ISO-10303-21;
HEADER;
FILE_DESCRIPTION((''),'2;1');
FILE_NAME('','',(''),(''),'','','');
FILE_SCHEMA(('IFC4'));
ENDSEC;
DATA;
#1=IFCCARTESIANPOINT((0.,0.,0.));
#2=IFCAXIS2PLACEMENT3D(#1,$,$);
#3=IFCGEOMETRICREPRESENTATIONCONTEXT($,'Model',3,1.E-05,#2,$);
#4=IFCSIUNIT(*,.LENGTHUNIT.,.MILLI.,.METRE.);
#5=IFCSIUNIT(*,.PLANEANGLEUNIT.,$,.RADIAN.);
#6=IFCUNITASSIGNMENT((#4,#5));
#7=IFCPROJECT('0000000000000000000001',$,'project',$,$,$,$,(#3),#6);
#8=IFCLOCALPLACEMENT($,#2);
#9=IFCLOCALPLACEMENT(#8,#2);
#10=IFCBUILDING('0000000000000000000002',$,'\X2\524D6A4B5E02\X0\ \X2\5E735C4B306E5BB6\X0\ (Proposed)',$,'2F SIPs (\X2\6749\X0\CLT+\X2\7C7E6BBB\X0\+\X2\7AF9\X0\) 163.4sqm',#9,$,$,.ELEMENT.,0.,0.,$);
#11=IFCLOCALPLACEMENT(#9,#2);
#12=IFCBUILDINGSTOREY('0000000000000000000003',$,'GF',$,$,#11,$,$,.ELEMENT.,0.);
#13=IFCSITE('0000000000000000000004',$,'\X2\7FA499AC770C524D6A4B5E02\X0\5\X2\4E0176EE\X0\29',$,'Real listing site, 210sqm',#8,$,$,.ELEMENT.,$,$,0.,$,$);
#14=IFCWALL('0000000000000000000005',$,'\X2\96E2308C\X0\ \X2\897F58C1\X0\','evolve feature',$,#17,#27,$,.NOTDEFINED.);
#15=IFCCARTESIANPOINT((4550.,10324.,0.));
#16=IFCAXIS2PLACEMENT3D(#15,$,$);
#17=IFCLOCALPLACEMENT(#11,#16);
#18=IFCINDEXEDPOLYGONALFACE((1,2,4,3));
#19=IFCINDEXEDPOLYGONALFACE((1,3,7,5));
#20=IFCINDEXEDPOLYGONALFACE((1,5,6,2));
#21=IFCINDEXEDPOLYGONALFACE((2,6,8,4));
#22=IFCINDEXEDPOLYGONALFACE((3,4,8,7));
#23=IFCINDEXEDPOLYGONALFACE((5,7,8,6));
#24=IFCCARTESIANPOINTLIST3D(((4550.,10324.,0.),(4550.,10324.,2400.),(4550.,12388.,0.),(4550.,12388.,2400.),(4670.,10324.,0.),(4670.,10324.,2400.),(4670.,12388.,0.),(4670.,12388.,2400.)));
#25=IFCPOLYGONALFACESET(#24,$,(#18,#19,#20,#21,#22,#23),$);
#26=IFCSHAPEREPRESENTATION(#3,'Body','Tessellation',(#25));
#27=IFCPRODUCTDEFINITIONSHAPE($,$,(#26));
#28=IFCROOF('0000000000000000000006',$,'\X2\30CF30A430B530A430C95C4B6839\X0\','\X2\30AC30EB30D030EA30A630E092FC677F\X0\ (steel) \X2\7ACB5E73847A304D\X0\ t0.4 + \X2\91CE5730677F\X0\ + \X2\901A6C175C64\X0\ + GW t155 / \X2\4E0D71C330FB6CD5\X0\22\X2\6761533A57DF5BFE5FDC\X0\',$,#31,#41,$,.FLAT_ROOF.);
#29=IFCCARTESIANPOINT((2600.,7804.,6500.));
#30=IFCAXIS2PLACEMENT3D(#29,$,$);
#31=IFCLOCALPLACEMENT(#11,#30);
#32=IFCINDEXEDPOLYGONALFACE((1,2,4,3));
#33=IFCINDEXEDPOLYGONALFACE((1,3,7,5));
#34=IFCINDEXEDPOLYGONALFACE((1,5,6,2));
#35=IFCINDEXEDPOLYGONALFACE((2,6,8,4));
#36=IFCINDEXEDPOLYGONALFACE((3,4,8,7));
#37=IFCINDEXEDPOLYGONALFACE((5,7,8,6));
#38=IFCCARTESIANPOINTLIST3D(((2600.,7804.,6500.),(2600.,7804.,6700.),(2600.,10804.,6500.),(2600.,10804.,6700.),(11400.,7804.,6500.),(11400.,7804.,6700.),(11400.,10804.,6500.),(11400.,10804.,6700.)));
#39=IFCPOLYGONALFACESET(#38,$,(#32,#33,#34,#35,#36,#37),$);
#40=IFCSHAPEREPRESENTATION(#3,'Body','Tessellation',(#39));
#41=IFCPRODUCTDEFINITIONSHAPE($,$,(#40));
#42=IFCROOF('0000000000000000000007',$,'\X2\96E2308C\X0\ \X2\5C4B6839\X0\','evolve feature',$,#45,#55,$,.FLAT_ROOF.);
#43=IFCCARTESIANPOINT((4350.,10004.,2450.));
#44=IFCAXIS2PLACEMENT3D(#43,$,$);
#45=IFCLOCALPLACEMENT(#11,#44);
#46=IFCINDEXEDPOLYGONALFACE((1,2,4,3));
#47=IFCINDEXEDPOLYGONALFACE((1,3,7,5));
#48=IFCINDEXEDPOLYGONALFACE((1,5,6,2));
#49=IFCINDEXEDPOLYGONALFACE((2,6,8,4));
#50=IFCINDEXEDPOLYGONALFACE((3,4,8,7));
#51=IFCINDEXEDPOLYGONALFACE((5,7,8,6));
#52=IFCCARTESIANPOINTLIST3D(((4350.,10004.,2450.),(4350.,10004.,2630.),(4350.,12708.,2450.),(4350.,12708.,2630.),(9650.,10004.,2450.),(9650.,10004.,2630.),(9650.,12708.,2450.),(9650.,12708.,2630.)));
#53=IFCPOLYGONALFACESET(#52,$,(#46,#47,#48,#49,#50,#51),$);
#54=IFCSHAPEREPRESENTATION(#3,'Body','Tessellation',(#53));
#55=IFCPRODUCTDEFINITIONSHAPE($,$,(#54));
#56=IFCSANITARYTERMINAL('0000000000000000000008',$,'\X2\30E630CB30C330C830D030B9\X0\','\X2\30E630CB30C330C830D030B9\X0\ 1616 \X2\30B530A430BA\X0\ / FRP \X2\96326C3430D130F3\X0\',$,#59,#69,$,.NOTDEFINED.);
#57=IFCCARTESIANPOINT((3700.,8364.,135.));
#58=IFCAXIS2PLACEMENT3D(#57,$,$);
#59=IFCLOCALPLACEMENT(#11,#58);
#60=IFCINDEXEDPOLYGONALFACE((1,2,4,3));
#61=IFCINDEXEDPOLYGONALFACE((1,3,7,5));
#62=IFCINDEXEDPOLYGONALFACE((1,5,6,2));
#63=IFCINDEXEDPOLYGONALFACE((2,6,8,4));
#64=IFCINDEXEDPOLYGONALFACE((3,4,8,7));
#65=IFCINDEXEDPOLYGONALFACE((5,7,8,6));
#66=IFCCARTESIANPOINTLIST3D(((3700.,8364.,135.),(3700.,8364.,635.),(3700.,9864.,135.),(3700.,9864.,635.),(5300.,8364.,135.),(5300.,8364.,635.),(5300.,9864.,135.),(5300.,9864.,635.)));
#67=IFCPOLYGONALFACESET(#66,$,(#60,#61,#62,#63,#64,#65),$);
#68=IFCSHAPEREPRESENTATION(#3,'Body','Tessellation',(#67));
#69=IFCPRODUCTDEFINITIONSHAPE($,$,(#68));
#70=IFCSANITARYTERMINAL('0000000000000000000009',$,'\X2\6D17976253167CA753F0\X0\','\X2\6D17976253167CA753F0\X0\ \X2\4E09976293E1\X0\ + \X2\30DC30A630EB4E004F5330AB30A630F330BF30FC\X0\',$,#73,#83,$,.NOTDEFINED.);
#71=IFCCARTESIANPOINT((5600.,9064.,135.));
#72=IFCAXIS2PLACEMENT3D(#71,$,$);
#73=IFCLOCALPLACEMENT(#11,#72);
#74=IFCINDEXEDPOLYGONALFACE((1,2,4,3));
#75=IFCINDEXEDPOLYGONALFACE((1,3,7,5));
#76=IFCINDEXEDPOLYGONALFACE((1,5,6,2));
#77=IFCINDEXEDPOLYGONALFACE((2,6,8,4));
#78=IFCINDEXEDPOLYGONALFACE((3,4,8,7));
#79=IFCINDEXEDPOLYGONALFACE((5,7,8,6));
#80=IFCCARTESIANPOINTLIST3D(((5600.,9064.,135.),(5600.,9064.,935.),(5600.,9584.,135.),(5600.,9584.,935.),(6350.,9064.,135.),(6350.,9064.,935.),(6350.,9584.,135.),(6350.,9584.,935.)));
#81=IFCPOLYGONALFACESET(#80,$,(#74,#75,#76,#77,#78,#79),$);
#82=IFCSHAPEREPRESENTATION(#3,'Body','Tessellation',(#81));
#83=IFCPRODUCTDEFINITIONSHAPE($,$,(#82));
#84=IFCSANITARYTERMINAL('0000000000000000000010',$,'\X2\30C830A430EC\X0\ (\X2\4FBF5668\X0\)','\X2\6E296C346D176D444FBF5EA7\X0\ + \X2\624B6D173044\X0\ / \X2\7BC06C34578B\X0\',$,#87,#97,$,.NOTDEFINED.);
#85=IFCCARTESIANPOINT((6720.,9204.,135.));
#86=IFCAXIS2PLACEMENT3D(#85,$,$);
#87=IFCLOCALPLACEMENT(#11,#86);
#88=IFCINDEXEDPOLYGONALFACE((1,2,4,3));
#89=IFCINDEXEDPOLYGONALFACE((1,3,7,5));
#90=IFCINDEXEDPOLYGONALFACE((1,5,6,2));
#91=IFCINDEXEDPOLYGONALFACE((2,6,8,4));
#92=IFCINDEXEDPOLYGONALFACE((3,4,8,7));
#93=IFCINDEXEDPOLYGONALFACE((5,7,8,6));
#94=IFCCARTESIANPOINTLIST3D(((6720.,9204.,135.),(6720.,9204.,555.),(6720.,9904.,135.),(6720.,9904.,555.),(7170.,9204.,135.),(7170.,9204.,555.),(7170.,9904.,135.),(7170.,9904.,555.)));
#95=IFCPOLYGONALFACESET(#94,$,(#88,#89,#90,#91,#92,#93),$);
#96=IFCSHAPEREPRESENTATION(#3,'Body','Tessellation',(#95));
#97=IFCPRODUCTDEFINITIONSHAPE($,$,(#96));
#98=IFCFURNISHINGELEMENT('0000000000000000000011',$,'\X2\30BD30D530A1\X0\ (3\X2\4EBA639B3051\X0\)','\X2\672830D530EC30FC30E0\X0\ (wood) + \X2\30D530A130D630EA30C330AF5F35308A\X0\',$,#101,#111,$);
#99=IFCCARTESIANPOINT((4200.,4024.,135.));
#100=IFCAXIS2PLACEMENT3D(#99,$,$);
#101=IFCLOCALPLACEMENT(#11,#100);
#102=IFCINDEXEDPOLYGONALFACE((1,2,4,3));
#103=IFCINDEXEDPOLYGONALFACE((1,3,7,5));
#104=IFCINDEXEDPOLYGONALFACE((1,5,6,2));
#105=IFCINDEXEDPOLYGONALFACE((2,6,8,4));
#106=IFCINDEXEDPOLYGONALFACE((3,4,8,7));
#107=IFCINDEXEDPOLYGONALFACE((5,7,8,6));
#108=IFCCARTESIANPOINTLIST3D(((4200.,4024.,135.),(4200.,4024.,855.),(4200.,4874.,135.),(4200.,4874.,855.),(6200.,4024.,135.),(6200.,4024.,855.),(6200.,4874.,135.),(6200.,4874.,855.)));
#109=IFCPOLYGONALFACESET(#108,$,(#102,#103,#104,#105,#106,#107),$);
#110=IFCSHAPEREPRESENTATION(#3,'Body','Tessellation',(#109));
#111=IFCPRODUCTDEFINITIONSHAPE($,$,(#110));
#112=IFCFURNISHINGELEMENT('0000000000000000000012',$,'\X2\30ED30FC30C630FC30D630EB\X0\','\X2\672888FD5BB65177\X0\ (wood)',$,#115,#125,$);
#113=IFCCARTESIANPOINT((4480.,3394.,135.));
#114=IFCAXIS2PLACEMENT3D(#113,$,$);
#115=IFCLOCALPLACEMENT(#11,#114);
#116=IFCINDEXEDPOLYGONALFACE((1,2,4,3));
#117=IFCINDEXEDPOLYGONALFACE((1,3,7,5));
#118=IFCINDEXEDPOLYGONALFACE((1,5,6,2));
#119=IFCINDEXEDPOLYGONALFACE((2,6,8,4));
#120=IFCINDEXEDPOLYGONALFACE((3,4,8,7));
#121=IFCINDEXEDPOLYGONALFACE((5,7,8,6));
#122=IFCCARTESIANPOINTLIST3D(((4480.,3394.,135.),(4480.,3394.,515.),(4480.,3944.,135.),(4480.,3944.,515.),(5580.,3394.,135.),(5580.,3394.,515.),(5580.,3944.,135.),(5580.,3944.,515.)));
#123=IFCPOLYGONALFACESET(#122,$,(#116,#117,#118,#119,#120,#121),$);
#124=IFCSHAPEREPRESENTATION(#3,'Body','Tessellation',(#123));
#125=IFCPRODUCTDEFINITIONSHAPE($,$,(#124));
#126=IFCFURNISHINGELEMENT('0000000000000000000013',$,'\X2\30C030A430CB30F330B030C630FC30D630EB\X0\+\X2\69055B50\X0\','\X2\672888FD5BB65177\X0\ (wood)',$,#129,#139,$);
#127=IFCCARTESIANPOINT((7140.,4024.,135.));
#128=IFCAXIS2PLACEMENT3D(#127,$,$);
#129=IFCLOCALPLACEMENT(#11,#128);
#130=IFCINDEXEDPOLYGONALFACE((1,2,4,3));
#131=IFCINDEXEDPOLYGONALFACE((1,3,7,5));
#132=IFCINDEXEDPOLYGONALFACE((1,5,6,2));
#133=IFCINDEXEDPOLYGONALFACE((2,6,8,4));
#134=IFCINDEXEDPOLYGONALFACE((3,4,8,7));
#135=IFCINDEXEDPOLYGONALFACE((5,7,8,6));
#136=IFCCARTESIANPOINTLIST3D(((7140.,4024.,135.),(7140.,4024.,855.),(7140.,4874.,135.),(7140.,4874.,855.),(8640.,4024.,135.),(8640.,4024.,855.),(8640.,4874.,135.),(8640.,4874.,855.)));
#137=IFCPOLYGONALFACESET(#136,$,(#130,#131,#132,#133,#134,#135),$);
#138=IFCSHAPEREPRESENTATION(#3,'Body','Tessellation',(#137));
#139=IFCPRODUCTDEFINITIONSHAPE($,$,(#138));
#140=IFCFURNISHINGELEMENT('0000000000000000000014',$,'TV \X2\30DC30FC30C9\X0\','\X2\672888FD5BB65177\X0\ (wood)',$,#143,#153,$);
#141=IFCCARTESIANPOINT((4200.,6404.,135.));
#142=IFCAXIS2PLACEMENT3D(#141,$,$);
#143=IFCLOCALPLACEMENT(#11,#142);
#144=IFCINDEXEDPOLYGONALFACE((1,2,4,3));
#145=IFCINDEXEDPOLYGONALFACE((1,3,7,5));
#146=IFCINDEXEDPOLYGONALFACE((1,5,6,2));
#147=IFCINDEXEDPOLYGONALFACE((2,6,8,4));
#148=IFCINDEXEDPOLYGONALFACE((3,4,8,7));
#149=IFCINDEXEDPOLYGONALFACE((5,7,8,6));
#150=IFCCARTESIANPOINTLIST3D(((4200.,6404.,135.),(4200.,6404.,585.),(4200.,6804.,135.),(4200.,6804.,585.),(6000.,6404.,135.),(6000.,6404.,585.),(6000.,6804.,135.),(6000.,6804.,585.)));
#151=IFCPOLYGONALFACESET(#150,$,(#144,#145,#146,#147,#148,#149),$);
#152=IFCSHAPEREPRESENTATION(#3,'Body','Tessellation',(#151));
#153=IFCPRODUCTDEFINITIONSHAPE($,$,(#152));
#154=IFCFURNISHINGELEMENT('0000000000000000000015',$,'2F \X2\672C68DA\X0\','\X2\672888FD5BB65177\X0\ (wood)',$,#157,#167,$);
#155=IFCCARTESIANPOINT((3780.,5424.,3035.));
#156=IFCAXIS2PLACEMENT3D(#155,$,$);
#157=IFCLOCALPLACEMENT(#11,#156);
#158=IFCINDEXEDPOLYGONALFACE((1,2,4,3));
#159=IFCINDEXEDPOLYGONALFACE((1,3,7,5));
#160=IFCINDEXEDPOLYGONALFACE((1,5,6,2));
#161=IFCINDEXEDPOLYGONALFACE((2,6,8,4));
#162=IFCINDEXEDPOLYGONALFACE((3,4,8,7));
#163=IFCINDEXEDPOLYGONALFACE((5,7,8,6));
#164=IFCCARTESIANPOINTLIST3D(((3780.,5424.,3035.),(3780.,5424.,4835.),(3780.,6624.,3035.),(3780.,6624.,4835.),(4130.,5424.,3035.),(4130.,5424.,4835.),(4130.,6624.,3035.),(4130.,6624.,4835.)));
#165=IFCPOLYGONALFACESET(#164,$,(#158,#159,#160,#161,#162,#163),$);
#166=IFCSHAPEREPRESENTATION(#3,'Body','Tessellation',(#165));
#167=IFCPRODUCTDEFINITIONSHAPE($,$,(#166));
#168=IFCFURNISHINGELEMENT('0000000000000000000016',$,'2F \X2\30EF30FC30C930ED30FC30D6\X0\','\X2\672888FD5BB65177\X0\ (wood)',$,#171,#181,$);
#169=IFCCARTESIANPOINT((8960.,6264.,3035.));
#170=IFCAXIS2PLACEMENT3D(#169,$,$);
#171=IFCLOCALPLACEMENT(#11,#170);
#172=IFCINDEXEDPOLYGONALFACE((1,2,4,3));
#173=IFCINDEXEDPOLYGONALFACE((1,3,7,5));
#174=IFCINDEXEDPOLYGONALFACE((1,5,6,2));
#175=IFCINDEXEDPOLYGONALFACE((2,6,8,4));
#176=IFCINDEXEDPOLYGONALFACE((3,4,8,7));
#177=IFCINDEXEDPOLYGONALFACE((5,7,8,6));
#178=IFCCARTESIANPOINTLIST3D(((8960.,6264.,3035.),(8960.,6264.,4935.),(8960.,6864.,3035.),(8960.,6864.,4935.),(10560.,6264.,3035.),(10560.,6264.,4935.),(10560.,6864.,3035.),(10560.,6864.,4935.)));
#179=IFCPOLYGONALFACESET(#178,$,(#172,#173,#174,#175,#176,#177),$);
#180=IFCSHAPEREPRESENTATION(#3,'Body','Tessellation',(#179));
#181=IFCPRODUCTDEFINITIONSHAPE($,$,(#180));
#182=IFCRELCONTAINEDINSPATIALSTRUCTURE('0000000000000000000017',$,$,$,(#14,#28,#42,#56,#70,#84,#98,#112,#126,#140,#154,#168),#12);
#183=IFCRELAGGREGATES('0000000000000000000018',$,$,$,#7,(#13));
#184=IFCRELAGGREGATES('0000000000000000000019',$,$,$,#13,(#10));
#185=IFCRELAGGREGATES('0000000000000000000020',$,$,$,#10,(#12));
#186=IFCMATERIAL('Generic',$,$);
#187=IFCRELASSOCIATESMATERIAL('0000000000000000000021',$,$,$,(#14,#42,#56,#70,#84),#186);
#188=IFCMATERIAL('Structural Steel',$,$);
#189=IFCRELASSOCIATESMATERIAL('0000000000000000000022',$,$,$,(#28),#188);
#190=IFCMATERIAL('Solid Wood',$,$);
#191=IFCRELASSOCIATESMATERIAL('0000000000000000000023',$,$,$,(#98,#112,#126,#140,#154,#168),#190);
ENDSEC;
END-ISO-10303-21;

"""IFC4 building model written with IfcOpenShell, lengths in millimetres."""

from ifc_helpers import new_model, si_unit, frame, frame_2d, origin, place, context, project, spatial, rectangle, extrude, material, element, save


model = new_model("IFC4")

# Units and contexts
model_context = context("Model", 3, precision=1e-05, world=origin())
ifc_project = project(units=[si_unit("LENGTHUNIT", "METRE", prefix="MILLI"), si_unit("PLANEANGLEUNIT", "RADIAN")], contexts=[model_context])

# Site, building, storey
site_placement = place(None, origin())
site = spatial("IfcSite", under=ifc_project, at=site_placement, Name="群馬県前橋市5丁目29", ObjectType="Real listing site, 210sqm", CompositionType="ELEMENT", RefElevation=0.0)
building_placement = place(site_placement, origin())
building = spatial("IfcBuilding", under=site, at=building_placement, Name="前橋市 平屋の家 (Proposed)", ObjectType="2F SIPs (杉CLT+籾殻+竹) 163.4sqm", CompositionType="ELEMENT", ElevationOfRefHeight=0.0, ElevationOfTerrain=0.0)
storey_placement = place(building_placement, origin())
storey = spatial("IfcBuildingStorey", under=building, at=storey_placement, Name="GF", CompositionType="ELEMENT", Elevation=0.0)

# Shared definitions
ifc_material_1 = material(Name="Generic")

# Shared definitions
ifc_material_2 = material(Name="Solid Wood")

# Wall
wall_1_placement = place(storey_placement, frame((4550.0, 10324.0, 0.0)))
element("IfcWall", 1, at=wall_1_placement, inside=storey, material=ifc_material_1, Name="離れ 西壁", Description="evolve feature", PredefinedType="NOTDEFINED", context=model_context, shape_type="SweptSolid", body=[
    extrude(rectangle(XDim=120.0, YDim=2064.0, at=frame_2d((60.0, 1032.0))), frame((4550.0, 10324.0, 0.0)), (0.0, 0.0, 1.0), 2400.0),
])

# Roofs
ifc_material_3 = material(Name="Structural Steel")
roof_1_placement = place(storey_placement, frame((2600.0, 7804.0, 6500.0)))
element("IfcRoof", 2, at=roof_1_placement, inside=storey, material=ifc_material_3, Name="ハイサイド屋根", Description="ガルバリウム鋼板 (steel) 立平葺き t0.4 + 野地板 + 通気層 + GW t155 / 不燃・法22条区域対応", PredefinedType="FLAT_ROOF", context=model_context, shape_type="SweptSolid", body=[
    extrude(rectangle(XDim=8800.0, YDim=3000.0, at=frame_2d((4400.0, 1500.0))), frame((2600.0, 7804.0, 6500.0)), (0.0, 0.0, 1.0), 200.0),
])
roof_2_placement = place(storey_placement, frame((4350.0, 10004.0, 2450.0)))
element("IfcRoof", 3, at=roof_2_placement, inside=storey, material=ifc_material_1, Name="離れ 屋根", Description="evolve feature", PredefinedType="FLAT_ROOF", context=model_context, shape_type="SweptSolid", body=[
    extrude(rectangle(XDim=5300.0, YDim=2704.0, at=frame_2d((2650.0, 1352.0))), frame((4350.0, 10004.0, 2450.0)), (0.0, 0.0, 1.0), 180.0),
])

# Sanitary terminals
sanitary_terminal_1_placement = place(storey_placement, frame((3700.0, 8364.0, 135.0)))
element("IfcSanitaryTerminal", 4, at=sanitary_terminal_1_placement, inside=storey, material=ifc_material_1, Name="ユニットバス", Description="ユニットバス 1616 サイズ / FRP 防水パン", PredefinedType="NOTDEFINED", context=model_context, shape_type="SweptSolid", body=[
    extrude(rectangle(XDim=1600.0, YDim=1500.0, at=frame_2d((800.0, 750.0))), frame((3700.0, 8364.0, 135.0)), (0.0, 0.0, 1.0), 500.0),
])
sanitary_terminal_2_placement = place(storey_placement, frame((5600.0, 9064.0, 135.0)))
element("IfcSanitaryTerminal", 5, at=sanitary_terminal_2_placement, inside=storey, material=ifc_material_1, Name="洗面化粧台", Description="洗面化粧台 三面鏡 + ボウル一体カウンター", PredefinedType="NOTDEFINED", context=model_context, shape_type="SweptSolid", body=[
    extrude(rectangle(XDim=750.0, YDim=520.0, at=frame_2d((375.0, 260.0))), frame((5600.0, 9064.0, 135.0)), (0.0, 0.0, 1.0), 800.0),
])
sanitary_terminal_3_placement = place(storey_placement, frame((6720.0, 9204.0, 135.0)))
element("IfcSanitaryTerminal", 6, at=sanitary_terminal_3_placement, inside=storey, material=ifc_material_1, Name="トイレ (便器)", Description="温水洗浄便座 + 手洗い / 節水型", PredefinedType="NOTDEFINED", context=model_context, shape_type="SweptSolid", body=[
    extrude(rectangle(XDim=450.0, YDim=700.0, at=frame_2d((225.0, 350.0))), frame((6720.0, 9204.0, 135.0)), (0.0, 0.0, 1.0), 420.0),
])

# Furnishing elements
furnishing_1_placement = place(storey_placement, frame((4200.0, 4024.0, 135.0)))
element("IfcFurnishingElement", 7, at=furnishing_1_placement, inside=storey, material=ifc_material_2, Name="ソファ (3人掛け)", Description="木フレーム (wood) + ファブリック張り", context=model_context, shape_type="SweptSolid", body=[
    extrude(rectangle(XDim=2000.0, YDim=850.0, at=frame_2d((1000.0, 425.0))), frame((4200.0, 4024.0, 135.0)), (0.0, 0.0, 1.0), 720.0),
])
furnishing_2_placement = place(storey_placement, frame((4480.0, 3394.0, 135.0)))
element("IfcFurnishingElement", 8, at=furnishing_2_placement, inside=storey, material=ifc_material_2, Name="ローテーブル", Description="木製家具 (wood)", context=model_context, shape_type="SweptSolid", body=[
    extrude(rectangle(XDim=1100.0, YDim=550.0, at=frame_2d((550.0, 275.0))), frame((4480.0, 3394.0, 135.0)), (0.0, 0.0, 1.0), 380.0),
])
furnishing_3_placement = place(storey_placement, frame((7140.0, 4024.0, 135.0)))
element("IfcFurnishingElement", 9, at=furnishing_3_placement, inside=storey, material=ifc_material_2, Name="ダイニングテーブル+椅子", Description="木製家具 (wood)", context=model_context, shape_type="SweptSolid", body=[
    extrude(rectangle(XDim=1500.0, YDim=850.0, at=frame_2d((750.0, 425.0))), frame((7140.0, 4024.0, 135.0)), (0.0, 0.0, 1.0), 720.0),
])
furnishing_4_placement = place(storey_placement, frame((4200.0, 6404.0, 135.0)))
element("IfcFurnishingElement", 10, at=furnishing_4_placement, inside=storey, material=ifc_material_2, Name="TV ボード", Description="木製家具 (wood)", context=model_context, shape_type="SweptSolid", body=[
    extrude(rectangle(XDim=1800.0, YDim=400.0, at=frame_2d((900.0, 200.0))), frame((4200.0, 6404.0, 135.0)), (0.0, 0.0, 1.0), 450.0),
])
furnishing_5_placement = place(storey_placement, frame((3780.0, 5424.0, 3035.0)))
element("IfcFurnishingElement", 11, at=furnishing_5_placement, inside=storey, material=ifc_material_2, Name="2F 本棚", Description="木製家具 (wood)", context=model_context, shape_type="SweptSolid", body=[
    extrude(rectangle(XDim=350.0, YDim=1200.0, at=frame_2d((175.0, 600.0))), frame((3780.0, 5424.0, 3035.0)), (0.0, 0.0, 1.0), 1800.0),
])
furnishing_6_placement = place(storey_placement, frame((8960.0, 6264.0, 3035.0)))
element("IfcFurnishingElement", 12, at=furnishing_6_placement, inside=storey, material=ifc_material_2, Name="2F ワードローブ", Description="木製家具 (wood)", context=model_context, shape_type="SweptSolid", body=[
    extrude(rectangle(XDim=1600.0, YDim=600.0, at=frame_2d((800.0, 300.0))), frame((8960.0, 6264.0, 3035.0)), (0.0, 0.0, 1.0), 1900.0),
])

save(model, "model.ifc")
